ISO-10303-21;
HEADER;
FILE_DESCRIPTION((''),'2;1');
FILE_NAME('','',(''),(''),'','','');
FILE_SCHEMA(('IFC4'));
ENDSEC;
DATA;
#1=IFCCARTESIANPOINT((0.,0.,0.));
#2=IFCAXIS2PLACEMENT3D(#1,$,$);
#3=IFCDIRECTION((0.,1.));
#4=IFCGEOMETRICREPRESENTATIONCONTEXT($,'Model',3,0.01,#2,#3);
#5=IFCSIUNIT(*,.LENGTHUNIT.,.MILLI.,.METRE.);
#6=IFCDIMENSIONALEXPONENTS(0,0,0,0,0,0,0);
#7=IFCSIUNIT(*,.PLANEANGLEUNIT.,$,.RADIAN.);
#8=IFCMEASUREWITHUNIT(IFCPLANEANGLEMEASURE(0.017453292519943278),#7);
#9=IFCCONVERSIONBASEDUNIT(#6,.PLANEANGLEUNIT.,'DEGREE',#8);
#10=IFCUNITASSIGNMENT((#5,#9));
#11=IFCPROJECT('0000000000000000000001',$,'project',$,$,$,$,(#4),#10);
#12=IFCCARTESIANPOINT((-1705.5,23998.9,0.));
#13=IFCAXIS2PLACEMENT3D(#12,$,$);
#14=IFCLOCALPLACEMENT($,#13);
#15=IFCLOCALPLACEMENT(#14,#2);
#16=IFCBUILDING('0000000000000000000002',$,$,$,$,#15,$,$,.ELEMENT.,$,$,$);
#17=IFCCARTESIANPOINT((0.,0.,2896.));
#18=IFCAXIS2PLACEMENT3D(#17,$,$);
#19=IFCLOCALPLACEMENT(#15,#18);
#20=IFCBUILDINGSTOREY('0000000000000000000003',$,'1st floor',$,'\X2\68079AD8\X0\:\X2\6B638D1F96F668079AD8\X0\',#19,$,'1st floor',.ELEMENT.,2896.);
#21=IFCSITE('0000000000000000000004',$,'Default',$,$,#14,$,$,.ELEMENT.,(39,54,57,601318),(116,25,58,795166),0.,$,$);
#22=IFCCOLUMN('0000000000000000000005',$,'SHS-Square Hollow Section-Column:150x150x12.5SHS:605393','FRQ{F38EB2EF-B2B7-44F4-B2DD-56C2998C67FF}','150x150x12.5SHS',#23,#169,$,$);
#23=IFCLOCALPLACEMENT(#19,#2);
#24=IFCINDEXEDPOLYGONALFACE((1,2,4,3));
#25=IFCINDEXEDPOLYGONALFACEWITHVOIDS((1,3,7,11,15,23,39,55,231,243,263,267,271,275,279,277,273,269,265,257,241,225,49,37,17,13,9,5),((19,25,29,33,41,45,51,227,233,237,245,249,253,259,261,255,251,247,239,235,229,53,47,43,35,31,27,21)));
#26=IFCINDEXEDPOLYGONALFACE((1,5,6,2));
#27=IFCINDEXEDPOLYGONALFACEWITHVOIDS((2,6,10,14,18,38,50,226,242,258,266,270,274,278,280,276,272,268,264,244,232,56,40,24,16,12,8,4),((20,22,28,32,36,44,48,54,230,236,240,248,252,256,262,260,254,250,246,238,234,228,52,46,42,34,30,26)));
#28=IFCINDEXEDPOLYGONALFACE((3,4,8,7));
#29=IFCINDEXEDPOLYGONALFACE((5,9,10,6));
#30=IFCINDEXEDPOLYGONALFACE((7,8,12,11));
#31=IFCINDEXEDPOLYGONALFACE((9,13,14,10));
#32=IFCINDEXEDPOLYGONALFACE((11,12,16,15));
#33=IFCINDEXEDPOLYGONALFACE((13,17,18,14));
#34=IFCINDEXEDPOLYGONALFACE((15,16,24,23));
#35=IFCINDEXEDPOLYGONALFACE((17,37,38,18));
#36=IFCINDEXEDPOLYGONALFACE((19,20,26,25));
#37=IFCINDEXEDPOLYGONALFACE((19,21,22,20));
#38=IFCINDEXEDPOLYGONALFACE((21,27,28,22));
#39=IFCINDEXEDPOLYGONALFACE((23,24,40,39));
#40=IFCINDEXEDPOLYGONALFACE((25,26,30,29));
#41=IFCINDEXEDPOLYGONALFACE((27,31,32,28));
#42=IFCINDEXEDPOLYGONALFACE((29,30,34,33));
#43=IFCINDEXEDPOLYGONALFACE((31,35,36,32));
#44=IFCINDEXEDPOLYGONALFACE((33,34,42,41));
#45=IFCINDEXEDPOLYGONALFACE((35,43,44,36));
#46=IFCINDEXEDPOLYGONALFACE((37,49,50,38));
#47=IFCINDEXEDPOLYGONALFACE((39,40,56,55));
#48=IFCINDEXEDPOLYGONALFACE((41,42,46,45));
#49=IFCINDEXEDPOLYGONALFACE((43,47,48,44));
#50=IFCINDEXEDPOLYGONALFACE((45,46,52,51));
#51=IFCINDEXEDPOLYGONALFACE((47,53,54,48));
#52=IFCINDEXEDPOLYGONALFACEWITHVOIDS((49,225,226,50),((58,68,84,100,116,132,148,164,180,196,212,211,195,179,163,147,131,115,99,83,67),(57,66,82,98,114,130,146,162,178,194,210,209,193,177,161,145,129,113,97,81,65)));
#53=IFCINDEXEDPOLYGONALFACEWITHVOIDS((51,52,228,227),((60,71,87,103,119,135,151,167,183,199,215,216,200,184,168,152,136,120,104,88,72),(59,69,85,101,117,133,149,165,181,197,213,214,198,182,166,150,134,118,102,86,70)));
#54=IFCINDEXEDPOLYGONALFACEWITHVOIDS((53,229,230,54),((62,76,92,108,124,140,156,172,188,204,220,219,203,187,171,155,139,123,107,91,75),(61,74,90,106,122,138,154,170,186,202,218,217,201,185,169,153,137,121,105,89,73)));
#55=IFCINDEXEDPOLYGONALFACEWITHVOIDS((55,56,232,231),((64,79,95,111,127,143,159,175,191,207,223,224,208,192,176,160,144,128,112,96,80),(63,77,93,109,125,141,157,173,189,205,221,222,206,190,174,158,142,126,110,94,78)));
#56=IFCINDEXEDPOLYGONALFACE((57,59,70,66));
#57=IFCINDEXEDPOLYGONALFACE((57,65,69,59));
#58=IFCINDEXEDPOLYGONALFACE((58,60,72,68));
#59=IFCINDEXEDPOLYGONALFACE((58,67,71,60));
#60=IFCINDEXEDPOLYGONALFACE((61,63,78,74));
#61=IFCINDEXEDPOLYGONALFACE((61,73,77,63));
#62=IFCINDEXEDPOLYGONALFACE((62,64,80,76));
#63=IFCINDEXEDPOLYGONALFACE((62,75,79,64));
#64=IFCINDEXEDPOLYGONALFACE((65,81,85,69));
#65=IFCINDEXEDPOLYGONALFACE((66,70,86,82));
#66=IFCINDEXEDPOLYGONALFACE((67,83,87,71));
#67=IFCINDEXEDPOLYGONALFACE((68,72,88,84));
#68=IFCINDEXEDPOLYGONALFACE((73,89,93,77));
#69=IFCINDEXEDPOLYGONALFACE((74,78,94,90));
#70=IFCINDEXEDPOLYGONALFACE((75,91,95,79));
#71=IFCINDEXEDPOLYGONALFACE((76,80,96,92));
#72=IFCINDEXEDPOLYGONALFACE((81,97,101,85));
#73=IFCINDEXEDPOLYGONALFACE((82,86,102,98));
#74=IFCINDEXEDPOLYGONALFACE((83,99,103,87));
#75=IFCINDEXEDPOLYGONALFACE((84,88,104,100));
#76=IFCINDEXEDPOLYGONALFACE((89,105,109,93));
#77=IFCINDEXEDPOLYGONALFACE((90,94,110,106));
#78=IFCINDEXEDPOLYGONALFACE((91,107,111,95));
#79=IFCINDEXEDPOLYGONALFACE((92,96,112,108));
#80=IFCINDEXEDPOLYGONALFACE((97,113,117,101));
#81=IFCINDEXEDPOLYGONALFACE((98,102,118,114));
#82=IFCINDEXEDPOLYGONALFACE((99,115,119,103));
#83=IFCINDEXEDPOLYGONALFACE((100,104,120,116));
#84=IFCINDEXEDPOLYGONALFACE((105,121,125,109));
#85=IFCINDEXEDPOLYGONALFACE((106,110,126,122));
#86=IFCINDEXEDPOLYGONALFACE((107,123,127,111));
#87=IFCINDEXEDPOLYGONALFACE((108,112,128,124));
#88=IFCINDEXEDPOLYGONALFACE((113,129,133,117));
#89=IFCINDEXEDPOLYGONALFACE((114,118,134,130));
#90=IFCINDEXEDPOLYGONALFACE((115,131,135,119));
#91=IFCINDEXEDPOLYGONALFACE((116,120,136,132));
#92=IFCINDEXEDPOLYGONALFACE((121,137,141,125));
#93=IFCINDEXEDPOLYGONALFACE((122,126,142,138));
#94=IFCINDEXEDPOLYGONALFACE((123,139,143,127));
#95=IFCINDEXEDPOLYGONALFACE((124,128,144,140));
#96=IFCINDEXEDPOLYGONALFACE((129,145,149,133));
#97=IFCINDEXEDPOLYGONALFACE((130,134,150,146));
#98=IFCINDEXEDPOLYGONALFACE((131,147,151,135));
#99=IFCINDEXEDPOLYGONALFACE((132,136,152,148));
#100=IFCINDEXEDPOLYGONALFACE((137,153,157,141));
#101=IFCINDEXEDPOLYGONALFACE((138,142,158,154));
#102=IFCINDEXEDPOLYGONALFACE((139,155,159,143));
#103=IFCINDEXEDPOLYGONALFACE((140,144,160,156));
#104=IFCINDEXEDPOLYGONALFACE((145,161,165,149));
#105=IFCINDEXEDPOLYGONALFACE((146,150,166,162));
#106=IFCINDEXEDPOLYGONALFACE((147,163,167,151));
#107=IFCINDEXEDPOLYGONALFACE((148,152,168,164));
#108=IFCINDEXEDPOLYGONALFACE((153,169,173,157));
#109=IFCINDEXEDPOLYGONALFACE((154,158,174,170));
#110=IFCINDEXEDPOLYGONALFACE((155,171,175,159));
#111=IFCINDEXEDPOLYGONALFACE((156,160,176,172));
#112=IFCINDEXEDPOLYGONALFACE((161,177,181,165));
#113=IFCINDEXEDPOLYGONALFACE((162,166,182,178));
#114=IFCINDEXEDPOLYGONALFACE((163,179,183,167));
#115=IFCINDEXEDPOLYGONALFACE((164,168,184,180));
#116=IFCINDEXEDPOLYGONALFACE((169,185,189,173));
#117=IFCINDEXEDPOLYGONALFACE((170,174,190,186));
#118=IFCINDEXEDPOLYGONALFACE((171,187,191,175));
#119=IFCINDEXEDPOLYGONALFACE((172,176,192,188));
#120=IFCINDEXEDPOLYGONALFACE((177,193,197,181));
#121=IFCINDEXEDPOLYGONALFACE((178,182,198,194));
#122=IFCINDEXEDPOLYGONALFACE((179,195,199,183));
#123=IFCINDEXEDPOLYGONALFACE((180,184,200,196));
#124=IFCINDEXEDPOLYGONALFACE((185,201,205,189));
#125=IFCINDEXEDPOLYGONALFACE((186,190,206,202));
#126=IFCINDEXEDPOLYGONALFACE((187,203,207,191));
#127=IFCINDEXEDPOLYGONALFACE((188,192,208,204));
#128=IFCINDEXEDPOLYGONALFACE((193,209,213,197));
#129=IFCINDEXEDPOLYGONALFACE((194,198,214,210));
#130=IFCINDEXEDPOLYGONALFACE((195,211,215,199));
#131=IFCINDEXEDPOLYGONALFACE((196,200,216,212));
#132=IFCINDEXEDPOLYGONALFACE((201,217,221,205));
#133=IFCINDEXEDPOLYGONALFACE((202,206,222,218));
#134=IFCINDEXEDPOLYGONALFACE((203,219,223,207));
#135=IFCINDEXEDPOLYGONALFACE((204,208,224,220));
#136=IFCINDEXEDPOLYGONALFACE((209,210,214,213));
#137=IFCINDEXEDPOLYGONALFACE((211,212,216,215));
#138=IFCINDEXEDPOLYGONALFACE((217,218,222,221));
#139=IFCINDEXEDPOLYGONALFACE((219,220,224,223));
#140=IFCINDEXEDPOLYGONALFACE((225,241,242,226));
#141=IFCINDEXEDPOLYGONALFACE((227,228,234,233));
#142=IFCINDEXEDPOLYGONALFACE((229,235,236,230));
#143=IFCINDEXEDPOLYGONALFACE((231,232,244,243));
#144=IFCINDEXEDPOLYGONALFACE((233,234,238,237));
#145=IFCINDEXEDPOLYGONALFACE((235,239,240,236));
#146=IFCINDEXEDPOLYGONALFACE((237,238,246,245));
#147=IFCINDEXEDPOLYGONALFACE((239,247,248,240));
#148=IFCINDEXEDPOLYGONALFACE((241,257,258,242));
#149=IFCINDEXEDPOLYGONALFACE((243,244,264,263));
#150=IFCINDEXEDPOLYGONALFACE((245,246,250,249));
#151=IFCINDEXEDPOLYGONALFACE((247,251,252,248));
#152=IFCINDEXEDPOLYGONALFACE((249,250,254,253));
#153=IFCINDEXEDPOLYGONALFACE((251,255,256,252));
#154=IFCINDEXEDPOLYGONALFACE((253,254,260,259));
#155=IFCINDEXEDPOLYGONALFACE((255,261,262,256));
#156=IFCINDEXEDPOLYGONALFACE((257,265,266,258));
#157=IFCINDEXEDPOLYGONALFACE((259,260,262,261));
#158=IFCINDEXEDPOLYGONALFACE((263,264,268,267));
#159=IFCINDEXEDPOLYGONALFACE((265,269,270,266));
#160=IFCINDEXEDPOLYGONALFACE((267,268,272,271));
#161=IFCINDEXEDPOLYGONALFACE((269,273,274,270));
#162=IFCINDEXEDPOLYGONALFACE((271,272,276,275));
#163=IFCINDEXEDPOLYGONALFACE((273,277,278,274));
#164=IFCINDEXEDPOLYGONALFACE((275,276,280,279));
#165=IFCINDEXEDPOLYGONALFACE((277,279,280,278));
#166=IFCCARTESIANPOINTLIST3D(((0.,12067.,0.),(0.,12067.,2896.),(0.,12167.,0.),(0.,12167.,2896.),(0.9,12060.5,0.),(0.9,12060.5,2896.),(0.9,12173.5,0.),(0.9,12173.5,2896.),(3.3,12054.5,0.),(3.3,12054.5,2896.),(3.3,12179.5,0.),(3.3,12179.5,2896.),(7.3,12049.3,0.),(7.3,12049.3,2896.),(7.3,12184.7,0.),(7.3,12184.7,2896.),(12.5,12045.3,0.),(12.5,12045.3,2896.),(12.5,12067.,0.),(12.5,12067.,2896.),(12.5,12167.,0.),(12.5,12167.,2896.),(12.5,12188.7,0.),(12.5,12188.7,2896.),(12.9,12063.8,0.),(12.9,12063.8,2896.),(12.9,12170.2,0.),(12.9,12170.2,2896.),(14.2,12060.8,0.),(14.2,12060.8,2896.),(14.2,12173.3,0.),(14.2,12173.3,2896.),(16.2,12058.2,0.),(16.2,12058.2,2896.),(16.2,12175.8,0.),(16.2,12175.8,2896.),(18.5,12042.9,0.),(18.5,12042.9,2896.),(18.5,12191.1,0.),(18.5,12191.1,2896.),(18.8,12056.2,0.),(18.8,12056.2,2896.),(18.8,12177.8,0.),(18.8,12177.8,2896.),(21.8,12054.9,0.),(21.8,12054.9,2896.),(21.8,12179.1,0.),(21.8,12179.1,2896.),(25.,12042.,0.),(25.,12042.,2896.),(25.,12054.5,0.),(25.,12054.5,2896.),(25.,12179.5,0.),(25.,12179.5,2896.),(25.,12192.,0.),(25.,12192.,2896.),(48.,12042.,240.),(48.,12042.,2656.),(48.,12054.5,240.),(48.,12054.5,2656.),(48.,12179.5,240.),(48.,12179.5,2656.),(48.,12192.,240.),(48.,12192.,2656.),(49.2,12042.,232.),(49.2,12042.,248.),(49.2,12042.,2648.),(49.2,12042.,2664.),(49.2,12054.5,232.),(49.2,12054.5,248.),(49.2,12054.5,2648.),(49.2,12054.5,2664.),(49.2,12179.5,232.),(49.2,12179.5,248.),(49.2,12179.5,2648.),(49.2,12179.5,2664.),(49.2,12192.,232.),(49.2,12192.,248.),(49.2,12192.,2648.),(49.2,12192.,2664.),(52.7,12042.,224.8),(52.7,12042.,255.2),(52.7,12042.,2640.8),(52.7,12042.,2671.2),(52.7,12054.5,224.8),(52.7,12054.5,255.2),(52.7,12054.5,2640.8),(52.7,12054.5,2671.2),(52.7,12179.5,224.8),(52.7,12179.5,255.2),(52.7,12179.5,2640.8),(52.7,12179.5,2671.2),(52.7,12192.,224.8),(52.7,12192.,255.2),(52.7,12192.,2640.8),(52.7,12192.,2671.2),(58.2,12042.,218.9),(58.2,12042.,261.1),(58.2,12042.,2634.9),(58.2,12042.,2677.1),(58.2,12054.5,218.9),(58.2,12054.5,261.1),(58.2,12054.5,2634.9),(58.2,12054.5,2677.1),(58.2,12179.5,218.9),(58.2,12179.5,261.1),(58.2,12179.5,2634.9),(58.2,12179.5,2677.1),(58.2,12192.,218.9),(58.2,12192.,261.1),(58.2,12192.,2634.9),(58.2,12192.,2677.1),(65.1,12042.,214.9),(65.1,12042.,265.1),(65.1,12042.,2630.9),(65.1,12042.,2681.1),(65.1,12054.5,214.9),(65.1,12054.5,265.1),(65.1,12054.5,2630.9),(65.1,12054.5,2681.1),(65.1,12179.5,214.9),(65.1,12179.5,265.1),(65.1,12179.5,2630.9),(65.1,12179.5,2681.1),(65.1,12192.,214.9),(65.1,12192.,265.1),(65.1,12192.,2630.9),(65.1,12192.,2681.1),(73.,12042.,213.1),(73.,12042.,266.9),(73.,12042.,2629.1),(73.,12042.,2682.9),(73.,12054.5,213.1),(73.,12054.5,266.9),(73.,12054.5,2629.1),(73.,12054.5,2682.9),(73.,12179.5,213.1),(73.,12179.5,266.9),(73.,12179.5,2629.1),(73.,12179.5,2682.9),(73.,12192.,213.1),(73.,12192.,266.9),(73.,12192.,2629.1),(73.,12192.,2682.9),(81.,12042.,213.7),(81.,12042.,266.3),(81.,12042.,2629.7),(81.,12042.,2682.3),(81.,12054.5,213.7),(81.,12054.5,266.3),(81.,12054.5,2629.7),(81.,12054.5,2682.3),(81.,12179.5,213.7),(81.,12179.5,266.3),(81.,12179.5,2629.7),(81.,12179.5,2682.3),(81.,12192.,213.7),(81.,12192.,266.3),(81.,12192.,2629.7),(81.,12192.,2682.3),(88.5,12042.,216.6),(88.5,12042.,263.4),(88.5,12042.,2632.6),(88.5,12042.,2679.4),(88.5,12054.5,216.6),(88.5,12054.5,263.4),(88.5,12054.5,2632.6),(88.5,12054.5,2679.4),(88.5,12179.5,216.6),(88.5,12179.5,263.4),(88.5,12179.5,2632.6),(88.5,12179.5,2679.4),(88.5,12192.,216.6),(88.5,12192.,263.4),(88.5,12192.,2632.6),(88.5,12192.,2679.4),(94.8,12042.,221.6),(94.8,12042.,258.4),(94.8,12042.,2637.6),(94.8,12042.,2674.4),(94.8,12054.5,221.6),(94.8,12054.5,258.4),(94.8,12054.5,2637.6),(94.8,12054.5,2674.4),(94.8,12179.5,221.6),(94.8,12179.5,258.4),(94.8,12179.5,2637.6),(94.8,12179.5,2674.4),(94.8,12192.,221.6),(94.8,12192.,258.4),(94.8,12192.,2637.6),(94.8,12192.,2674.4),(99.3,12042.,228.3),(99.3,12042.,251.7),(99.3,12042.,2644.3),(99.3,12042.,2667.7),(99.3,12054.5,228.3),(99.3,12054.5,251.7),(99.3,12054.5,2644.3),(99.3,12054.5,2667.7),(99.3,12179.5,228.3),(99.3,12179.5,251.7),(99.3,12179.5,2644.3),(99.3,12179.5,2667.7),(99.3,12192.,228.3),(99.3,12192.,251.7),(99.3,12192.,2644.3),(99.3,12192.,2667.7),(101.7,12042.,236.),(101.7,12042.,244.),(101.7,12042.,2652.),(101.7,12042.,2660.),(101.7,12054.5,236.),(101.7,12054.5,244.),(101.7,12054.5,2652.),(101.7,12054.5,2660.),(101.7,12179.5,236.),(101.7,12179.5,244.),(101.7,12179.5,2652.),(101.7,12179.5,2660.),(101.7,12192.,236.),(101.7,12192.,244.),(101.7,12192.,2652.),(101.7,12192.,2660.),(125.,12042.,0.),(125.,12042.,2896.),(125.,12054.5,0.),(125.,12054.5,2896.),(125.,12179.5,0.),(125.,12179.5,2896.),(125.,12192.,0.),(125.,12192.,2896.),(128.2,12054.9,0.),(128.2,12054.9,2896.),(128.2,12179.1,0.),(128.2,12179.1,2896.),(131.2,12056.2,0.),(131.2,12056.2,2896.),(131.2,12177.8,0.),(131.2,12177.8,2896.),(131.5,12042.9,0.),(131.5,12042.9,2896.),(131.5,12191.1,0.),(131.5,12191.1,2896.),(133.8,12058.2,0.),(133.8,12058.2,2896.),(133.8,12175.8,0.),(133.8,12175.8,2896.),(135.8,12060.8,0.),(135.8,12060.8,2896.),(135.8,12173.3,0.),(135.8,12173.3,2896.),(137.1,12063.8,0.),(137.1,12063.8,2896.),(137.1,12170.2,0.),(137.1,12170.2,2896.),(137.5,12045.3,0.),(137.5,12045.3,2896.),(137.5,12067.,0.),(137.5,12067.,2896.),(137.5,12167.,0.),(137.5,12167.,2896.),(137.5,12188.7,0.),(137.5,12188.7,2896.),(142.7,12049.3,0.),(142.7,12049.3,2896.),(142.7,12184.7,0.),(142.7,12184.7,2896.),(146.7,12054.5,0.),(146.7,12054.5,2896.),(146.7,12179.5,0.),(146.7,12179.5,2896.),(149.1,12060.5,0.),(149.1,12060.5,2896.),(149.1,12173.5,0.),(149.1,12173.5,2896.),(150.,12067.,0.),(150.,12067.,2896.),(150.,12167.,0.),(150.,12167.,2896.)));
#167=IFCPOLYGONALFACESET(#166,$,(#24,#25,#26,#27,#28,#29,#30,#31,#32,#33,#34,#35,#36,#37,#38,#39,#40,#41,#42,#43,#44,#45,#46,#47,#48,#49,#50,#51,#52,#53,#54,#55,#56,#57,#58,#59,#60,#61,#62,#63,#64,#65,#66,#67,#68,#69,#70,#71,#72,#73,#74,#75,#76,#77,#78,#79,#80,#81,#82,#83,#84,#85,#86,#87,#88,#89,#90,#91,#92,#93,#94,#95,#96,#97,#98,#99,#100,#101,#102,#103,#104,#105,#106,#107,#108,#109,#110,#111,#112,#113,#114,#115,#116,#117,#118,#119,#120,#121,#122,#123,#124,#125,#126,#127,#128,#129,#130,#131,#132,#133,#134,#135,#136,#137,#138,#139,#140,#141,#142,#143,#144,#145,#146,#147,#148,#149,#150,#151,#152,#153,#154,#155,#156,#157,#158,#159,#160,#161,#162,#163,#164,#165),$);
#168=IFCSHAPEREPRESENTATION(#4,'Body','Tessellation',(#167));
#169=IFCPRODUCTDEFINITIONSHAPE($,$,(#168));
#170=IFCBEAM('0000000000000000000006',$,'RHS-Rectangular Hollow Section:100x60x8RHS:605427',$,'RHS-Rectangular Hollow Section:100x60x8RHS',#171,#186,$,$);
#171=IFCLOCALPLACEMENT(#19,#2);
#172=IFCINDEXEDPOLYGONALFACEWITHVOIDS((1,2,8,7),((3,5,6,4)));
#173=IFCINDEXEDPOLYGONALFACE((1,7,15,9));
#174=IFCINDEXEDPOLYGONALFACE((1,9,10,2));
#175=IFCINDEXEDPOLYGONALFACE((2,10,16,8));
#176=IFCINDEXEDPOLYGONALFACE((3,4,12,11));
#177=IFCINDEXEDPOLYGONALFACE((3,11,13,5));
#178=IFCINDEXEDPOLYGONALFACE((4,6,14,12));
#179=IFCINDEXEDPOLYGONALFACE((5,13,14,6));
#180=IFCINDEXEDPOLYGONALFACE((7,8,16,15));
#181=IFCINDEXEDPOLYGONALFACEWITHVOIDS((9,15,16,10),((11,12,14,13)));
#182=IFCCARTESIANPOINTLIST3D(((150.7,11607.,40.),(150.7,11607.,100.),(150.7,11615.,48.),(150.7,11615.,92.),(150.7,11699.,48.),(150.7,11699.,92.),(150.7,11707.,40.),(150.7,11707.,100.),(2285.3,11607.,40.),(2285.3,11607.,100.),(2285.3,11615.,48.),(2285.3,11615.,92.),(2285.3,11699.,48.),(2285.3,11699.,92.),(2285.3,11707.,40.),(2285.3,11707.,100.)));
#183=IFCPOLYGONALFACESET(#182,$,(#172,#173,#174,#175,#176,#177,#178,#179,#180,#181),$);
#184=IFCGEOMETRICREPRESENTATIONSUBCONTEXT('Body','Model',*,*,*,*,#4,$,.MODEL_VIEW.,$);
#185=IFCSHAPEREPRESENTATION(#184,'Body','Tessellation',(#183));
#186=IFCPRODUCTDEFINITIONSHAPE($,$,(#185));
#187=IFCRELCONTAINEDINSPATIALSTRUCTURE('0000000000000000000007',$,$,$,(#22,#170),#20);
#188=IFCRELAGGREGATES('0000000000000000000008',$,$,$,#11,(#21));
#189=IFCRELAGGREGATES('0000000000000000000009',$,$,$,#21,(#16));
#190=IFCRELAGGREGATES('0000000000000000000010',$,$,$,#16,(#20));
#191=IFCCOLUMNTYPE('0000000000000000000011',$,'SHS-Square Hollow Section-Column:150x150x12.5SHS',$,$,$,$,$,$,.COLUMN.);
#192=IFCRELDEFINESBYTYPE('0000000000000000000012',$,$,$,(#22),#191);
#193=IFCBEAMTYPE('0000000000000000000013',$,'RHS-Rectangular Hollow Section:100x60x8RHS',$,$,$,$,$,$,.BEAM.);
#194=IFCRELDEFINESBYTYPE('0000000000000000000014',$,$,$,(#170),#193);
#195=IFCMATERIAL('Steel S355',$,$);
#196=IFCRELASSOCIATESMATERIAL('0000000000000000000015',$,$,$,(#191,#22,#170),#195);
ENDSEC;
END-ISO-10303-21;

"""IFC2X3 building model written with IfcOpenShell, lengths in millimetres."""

from ifc_helpers import new_model, entity, si_unit, converted_unit, direction, frame, frame_2d, origin, origin_2d, place, context, subcontext, project, spatial, circle_curve, rectangle, hollow_rectangle, outline, extrude, boolean, material, type_object, element, save


model = new_model("IFC2X3")

# Units and contexts
model_context = context("Model", 3, precision=0.01, world=origin(), true_north=direction((0.0, 1.0)))
body_context = subcontext(model_context, "Body", "Model", "MODEL_VIEW")
ifc_project = project(units=[si_unit("LENGTHUNIT", "METRE", prefix="MILLI"), converted_unit("PLANEANGLEUNIT", "DEGREE", entity("IfcPlaneAngleMeasure", 0.017453292519943278), si_unit("PLANEANGLEUNIT", "RADIAN"), dimensions=[0, 0, 0, 0, 0, 0, 0])], contexts=[model_context])

# Site, building, storey
site_placement = place(None, frame((-1705.5, 23998.9, 0.0)))
site = spatial("IfcSite", under=ifc_project, at=site_placement, Name="Default", CompositionType="ELEMENT", RefLatitude=(39, 54, 57, 601318), RefLongitude=(116, 25, 58, 795166), RefElevation=0.0)
building_placement = place(site_placement, origin())
building = spatial("IfcBuilding", under=site, at=building_placement, CompositionType="ELEMENT")
storey_placement = place(building_placement, frame((0.0, 0.0, 2896.0)))
storey = spatial("IfcBuildingStorey", under=building, at=storey_placement, Name="1st floor", ObjectType="标高:正负零标高", LongName="1st floor", CompositionType="ELEMENT", Elevation=2896.0)

# Shared definitions
ifc_material_1 = material(Name="Steel S355")

# Column, openings
column_type_1 = type_object("IfcColumnType", Name="SHS-Square Hollow Section-Column:150x150x12.5SHS", PredefinedType="COLUMN", material=ifc_material_1)
column_1_placement = place(storey_placement, frame((75.0, 12117.0, 2896.0), z_axis=(0.0, 0.0, 1.0), x_axis=(0.0, -1.0, 0.0)))
column_1 = element("IfcColumn", 1, at=column_1_placement, inside=storey, type_object=column_type_1, material=ifc_material_1, Name="SHS-Square Hollow Section-Column:150x150x12.5SHS:605393", Description="FRQ{F38EB2EF-B2B7-44F4-B2DD-56C2998C67FF}", ObjectType="150x150x12.5SHS", context=model_context, shape_type="SweptSolid", body=[
    extrude(hollow_rectangle(XDim=150.0, YDim=150.0, WallThickness=12.5, InnerFilletRadius=12.5, OuterFilletRadius=25.0, at=origin_2d()), origin(), (0.0, 0.0, -1.0), 2896.0),
])
opening_1_placement = place(column_1_placement, frame((175.1, 0.0, -2896.0), z_axis=(-1.0, 0.0, 0.0), x_axis=(0.0, -1.0, 0.0)))
element("IfcOpeningElement", 2, at=opening_1_placement, cuts=column_1, ObjectType="Opening", context=model_context, shape_type="SweptSolid", body=[
    extrude(outline(circle_curve(frame_2d((0.0, 240.0), x_axis=(1.0, 0.0)), 27.0)), origin(), (0.0, 0.0, 1.0), 350.2),
])
opening_2_placement = place(column_1_placement, frame((175.1, 0.0, 0.0), z_axis=(-1.0, 0.0, 0.0), x_axis=(0.0, -1.0, 0.0)))
element("IfcOpeningElement", 3, at=opening_2_placement, cuts=column_1, ObjectType="Opening", context=model_context, shape_type="SweptSolid", body=[
    extrude(outline(circle_curve(frame_2d((0.0, -240.0), x_axis=(1.0, 0.0)), 27.0)), origin(), (0.0, 0.0, 1.0), 350.2),
])

# Beam
beam_type_1 = type_object("IfcBeamType", Name="RHS-Rectangular Hollow Section:100x60x8RHS", PredefinedType="BEAM")
beam_1_placement = place(storey_placement, frame((150.7, 11707.0, 70.0)))
element("IfcBeam", 4, at=beam_1_placement, inside=storey, type_object=beam_type_1, material=ifc_material_1, Name="RHS-Rectangular Hollow Section:100x60x8RHS:605427", ObjectType="RHS-Rectangular Hollow Section:100x60x8RHS", context=body_context, shape_type="SweptSolid", body=[
    boolean("DIFFERENCE", extrude(rectangle(XDim=60.0, YDim=100.0, at=frame_2d((0.0, 0.0), x_axis=(1.0, 0.0))), frame((0.0, -50.0, 0.0), z_axis=(1.0, 0.0, 0.0), x_axis=(0.0, 0.0, -1.0)), (0.0, 0.0, 1.0), 2134.6), extrude(rectangle(XDim=44.0, YDim=84.0, at=frame_2d((0.0, 0.0), x_axis=(0.0, 1.0))), frame((2134.6, -50.0, 0.0), z_axis=(-1.0, 0.0, 0.0), x_axis=(0.0, 1.0, 0.0)), (0.0, 0.0, 1.0), 2134.6)),
])

save(model, "model.ifc")
